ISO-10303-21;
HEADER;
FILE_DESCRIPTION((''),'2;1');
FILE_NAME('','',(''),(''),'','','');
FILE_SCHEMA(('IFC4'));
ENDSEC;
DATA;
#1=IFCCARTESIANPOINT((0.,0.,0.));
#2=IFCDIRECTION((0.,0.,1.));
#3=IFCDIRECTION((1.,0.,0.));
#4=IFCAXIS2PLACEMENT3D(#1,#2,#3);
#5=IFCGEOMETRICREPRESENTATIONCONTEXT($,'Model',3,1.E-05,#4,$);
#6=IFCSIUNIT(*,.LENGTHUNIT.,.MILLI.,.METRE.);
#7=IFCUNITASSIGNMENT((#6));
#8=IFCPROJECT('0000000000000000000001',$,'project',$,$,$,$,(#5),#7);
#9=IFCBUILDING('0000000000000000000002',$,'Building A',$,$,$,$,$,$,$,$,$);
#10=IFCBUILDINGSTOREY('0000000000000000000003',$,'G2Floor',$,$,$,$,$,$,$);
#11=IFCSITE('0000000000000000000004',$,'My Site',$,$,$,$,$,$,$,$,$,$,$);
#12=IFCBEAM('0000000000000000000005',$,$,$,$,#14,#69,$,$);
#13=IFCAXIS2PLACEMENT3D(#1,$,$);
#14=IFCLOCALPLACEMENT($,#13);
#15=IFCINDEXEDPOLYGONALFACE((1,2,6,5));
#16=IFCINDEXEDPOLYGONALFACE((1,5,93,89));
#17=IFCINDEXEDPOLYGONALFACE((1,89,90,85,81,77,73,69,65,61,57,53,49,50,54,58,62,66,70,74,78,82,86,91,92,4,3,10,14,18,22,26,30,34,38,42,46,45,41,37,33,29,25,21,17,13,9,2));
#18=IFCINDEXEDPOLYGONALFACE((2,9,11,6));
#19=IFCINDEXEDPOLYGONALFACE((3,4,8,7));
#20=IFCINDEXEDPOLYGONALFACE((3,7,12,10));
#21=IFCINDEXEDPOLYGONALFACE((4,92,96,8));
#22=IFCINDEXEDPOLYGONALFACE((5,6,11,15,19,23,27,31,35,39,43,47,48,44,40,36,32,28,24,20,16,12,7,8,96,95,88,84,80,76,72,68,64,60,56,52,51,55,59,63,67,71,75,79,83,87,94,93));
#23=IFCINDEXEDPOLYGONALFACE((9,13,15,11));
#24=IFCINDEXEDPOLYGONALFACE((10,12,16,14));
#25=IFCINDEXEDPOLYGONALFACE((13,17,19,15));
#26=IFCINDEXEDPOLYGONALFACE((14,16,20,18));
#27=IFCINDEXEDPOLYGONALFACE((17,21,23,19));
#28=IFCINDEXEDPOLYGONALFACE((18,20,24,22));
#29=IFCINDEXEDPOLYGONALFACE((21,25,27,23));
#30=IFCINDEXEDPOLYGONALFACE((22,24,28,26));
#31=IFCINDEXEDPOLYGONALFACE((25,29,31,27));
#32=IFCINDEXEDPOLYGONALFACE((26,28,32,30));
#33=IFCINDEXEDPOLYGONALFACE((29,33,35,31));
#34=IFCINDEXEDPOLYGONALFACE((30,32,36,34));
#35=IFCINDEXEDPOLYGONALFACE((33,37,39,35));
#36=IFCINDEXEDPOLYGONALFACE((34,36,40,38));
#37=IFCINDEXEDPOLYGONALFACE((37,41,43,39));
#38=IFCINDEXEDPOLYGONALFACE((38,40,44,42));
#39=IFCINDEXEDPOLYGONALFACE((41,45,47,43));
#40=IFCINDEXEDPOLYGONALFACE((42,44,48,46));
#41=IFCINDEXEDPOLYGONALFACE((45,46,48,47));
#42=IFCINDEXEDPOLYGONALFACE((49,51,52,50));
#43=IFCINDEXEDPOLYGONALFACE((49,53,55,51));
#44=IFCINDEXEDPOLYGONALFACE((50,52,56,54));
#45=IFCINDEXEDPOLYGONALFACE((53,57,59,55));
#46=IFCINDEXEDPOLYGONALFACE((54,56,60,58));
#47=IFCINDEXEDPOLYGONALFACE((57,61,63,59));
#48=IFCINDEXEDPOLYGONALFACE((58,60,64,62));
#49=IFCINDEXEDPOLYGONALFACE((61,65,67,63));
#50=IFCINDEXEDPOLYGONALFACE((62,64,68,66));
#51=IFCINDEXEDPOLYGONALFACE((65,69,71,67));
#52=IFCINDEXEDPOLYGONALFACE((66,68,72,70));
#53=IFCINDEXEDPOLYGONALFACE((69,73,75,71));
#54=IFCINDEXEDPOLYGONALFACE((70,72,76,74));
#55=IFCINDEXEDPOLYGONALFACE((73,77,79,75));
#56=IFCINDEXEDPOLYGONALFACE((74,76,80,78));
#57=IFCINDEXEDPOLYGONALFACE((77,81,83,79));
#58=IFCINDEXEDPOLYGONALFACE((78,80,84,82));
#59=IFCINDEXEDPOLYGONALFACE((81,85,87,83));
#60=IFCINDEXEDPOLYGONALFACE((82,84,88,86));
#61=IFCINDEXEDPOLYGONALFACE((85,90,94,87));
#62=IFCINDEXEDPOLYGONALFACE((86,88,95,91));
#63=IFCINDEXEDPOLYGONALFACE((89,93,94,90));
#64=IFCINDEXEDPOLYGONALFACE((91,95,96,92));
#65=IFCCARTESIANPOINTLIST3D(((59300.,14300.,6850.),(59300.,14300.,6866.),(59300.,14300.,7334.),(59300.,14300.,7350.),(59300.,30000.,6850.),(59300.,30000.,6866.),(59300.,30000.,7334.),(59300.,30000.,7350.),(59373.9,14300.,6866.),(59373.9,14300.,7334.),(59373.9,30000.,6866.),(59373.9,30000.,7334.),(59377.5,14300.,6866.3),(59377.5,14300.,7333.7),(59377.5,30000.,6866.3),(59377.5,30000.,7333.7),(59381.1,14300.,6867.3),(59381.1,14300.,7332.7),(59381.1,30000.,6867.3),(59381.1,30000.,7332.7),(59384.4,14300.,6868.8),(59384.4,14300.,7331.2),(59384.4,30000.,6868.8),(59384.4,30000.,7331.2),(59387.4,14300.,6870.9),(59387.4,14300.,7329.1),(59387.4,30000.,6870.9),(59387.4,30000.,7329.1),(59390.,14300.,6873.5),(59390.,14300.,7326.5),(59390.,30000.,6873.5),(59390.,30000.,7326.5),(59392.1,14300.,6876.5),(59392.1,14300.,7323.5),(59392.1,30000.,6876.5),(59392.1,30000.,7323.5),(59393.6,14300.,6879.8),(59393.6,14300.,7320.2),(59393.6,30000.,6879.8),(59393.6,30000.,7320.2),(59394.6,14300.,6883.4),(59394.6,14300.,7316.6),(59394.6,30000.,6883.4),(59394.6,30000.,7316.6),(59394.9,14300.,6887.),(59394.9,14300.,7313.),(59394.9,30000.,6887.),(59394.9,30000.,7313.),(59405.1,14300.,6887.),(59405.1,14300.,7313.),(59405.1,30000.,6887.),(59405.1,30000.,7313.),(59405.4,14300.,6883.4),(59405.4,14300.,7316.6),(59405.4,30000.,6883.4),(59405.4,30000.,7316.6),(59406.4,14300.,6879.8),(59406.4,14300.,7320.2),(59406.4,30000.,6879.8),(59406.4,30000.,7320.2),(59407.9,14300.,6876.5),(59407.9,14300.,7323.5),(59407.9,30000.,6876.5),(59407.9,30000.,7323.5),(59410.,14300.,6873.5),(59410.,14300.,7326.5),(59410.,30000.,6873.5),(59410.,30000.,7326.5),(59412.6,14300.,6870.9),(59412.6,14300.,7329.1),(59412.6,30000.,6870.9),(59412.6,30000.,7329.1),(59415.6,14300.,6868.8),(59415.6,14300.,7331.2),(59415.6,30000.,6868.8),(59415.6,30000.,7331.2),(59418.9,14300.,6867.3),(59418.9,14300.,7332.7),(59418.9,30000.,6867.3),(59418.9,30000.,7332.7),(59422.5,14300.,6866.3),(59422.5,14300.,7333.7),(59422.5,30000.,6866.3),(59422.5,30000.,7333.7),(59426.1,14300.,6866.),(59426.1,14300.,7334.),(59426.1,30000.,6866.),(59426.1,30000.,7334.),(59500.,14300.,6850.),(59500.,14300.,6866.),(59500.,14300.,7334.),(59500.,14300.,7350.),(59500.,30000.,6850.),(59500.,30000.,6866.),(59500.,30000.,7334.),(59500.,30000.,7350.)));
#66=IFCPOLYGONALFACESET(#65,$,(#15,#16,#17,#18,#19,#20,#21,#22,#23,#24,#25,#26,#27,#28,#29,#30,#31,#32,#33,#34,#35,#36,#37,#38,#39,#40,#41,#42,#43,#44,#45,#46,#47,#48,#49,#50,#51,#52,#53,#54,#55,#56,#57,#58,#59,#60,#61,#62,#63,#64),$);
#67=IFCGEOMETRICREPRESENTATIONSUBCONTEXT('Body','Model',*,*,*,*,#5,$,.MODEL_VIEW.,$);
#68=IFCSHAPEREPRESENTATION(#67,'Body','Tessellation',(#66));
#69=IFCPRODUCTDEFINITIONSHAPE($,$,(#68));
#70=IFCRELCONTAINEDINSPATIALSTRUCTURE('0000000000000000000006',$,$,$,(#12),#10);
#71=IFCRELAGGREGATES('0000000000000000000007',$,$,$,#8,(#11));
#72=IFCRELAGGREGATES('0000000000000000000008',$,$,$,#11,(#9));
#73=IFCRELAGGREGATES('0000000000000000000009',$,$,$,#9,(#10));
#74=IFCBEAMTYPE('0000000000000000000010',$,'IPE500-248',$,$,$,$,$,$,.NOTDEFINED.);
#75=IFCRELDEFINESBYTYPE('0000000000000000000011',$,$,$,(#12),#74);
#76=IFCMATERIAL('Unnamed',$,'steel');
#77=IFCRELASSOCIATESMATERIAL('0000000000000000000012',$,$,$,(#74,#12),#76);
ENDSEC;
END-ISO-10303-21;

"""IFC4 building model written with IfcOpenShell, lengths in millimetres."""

from ifc_helpers import new_model, si_unit, frame, origin_with_axes, place, context, subcontext, project, spatial, polyline, outline, extrude, material, material_profile, profile_set, profile_usage, type_object, element, save


model = new_model("IFC4")

# Units and contexts
model_context = context("Model", 3, precision=1e-05, world=origin_with_axes())
body_context = subcontext(model_context, "Body", "Model", "MODEL_VIEW")
ifc_project = project(units=[si_unit("LENGTHUNIT", "METRE", prefix="MILLI")], contexts=[model_context])

# Site, building, storey
site = spatial("IfcSite", under=ifc_project, Name="My Site")
building = spatial("IfcBuilding", under=site, Name="Building A")
storey = spatial("IfcBuildingStorey", under=building, Name="G2Floor")

# Beam
ifc_material_1 = material(Name="Unnamed", Category="steel")
ifc_material_profile_1 = material_profile(ifc_material_1, outline(polyline([(100.0, -250.0), (100.0, -234.0), (100.0, -234.0), (26.1, -234.0), (26.1, -234.0), (22.5, -233.7), (22.5, -233.7), (18.9, -232.7), (18.9, -232.7), (15.6, -231.2), (15.6, -231.2), (12.6, -229.1), (12.6, -229.1), (10.0, -226.5), (10.0, -226.5), (7.9, -223.5), (7.9, -223.5), (6.4, -220.2), (6.4, -220.2), (5.4, -216.6), (5.4, -216.6), (5.1, -213.0), (5.1, -213.0), (5.1, 213.0), (5.1, 213.0), (5.4, 216.6), (5.4, 216.6), (6.4, 220.2), (6.4, 220.2), (7.9, 223.5), (7.9, 223.5), (10.0, 226.5), (10.0, 226.5), (12.6, 229.1), (12.6, 229.1), (15.6, 231.2), (15.6, 231.2), (18.9, 232.7), (18.9, 232.7), (22.5, 233.7), (22.5, 233.7), (26.1, 234.0), (26.1, 234.0), (100.0, 234.0), (100.0, 234.0), (100.0, 250.0), (100.0, 250.0), (-100.0, 250.0), (-100.0, 250.0), (-100.0, 234.0), (-100.0, 234.0), (-26.1, 234.0), (-26.1, 234.0), (-22.5, 233.7), (-22.5, 233.7), (-18.9, 232.7), (-18.9, 232.7), (-15.6, 231.2), (-15.6, 231.2), (-12.6, 229.1), (-12.6, 229.1), (-10.0, 226.5), (-10.0, 226.5), (-7.9, 223.5), (-7.9, 223.5), (-6.4, 220.2), (-6.4, 220.2), (-5.4, 216.6), (-5.4, 216.6), (-5.1, 213.0), (-5.1, 213.0), (-5.1, -213.0), (-5.1, -213.0), (-5.4, -216.6), (-5.4, -216.6), (-6.4, -220.2), (-6.4, -220.2), (-7.9, -223.5), (-7.9, -223.5), (-10.0, -226.5), (-10.0, -226.5), (-12.6, -229.1), (-12.6, -229.1), (-15.6, -231.2), (-15.6, -231.2), (-18.9, -232.7), (-18.9, -232.7), (-22.5, -233.7), (-22.5, -233.7), (-26.1, -234.0), (-26.1, -234.0), (-100.0, -234.0), (-100.0, -234.0), (-100.0, -250.0), (-100.0, -250.0), (100.0, -250.0)])))
ifc_profile_set_1 = profile_set([ifc_material_profile_1], Name="IPE500-248")
ifc_profile_usage_1 = profile_usage(ifc_profile_set_1)
beam_type_1 = type_object("IfcBeamType", Name="IPE500-248", PredefinedType="NOTDEFINED", material=ifc_profile_set_1)
beam_1_placement = place(None, frame((59400.0, 14300.0, 7100.0), z_axis=(0.0, 1.0, 0.0), x_axis=(1.0, 0.0, 0.0)))
element("IfcBeam", 1, at=beam_1_placement, inside=storey, type_object=beam_type_1, material=ifc_profile_usage_1, context=body_context, shape_type="SweptSolid", body=[
    extrude(outline(polyline([(100.0, -250.0), (100.0, -234.0), (100.0, -234.0), (26.1, -234.0), (26.1, -234.0), (22.5, -233.7), (22.5, -233.7), (18.9, -232.7), (18.9, -232.7), (15.6, -231.2), (15.6, -231.2), (12.6, -229.1), (12.6, -229.1), (10.0, -226.5), (10.0, -226.5), (7.9, -223.5), (7.9, -223.5), (6.4, -220.2), (6.4, -220.2), (5.4, -216.6), (5.4, -216.6), (5.1, -213.0), (5.1, -213.0), (5.1, 213.0), (5.1, 213.0), (5.4, 216.6), (5.4, 216.6), (6.4, 220.2), (6.4, 220.2), (7.9, 223.5), (7.9, 223.5), (10.0, 226.5), (10.0, 226.5), (12.6, 229.1), (12.6, 229.1), (15.6, 231.2), (15.6, 231.2), (18.9, 232.7), (18.9, 232.7), (22.5, 233.7), (22.5, 233.7), (26.1, 234.0), (26.1, 234.0), (100.0, 234.0), (100.0, 234.0), (100.0, 250.0), (100.0, 250.0), (-100.0, 250.0), (-100.0, 250.0), (-100.0, 234.0), (-100.0, 234.0), (-26.1, 234.0), (-26.1, 234.0), (-22.5, 233.7), (-22.5, 233.7), (-18.9, 232.7), (-18.9, 232.7), (-15.6, 231.2), (-15.6, 231.2), (-12.6, 229.1), (-12.6, 229.1), (-10.0, 226.5), (-10.0, 226.5), (-7.9, 223.5), (-7.9, 223.5), (-6.4, 220.2), (-6.4, 220.2), (-5.4, 216.6), (-5.4, 216.6), (-5.1, 213.0), (-5.1, 213.0), (-5.1, -213.0), (-5.1, -213.0), (-5.4, -216.6), (-5.4, -216.6), (-6.4, -220.2), (-6.4, -220.2), (-7.9, -223.5), (-7.9, -223.5), (-10.0, -226.5), (-10.0, -226.5), (-12.6, -229.1), (-12.6, -229.1), (-15.6, -231.2), (-15.6, -231.2), (-18.9, -232.7), (-18.9, -232.7), (-22.5, -233.7), (-22.5, -233.7), (-26.1, -234.0), (-26.1, -234.0), (-100.0, -234.0), (-100.0, -234.0), (-100.0, -250.0), (-100.0, -250.0), (100.0, -250.0)])), origin_with_axes(), (0.0, 0.0, 1.0), 15700.0),
])

save(model, "model.ifc")
